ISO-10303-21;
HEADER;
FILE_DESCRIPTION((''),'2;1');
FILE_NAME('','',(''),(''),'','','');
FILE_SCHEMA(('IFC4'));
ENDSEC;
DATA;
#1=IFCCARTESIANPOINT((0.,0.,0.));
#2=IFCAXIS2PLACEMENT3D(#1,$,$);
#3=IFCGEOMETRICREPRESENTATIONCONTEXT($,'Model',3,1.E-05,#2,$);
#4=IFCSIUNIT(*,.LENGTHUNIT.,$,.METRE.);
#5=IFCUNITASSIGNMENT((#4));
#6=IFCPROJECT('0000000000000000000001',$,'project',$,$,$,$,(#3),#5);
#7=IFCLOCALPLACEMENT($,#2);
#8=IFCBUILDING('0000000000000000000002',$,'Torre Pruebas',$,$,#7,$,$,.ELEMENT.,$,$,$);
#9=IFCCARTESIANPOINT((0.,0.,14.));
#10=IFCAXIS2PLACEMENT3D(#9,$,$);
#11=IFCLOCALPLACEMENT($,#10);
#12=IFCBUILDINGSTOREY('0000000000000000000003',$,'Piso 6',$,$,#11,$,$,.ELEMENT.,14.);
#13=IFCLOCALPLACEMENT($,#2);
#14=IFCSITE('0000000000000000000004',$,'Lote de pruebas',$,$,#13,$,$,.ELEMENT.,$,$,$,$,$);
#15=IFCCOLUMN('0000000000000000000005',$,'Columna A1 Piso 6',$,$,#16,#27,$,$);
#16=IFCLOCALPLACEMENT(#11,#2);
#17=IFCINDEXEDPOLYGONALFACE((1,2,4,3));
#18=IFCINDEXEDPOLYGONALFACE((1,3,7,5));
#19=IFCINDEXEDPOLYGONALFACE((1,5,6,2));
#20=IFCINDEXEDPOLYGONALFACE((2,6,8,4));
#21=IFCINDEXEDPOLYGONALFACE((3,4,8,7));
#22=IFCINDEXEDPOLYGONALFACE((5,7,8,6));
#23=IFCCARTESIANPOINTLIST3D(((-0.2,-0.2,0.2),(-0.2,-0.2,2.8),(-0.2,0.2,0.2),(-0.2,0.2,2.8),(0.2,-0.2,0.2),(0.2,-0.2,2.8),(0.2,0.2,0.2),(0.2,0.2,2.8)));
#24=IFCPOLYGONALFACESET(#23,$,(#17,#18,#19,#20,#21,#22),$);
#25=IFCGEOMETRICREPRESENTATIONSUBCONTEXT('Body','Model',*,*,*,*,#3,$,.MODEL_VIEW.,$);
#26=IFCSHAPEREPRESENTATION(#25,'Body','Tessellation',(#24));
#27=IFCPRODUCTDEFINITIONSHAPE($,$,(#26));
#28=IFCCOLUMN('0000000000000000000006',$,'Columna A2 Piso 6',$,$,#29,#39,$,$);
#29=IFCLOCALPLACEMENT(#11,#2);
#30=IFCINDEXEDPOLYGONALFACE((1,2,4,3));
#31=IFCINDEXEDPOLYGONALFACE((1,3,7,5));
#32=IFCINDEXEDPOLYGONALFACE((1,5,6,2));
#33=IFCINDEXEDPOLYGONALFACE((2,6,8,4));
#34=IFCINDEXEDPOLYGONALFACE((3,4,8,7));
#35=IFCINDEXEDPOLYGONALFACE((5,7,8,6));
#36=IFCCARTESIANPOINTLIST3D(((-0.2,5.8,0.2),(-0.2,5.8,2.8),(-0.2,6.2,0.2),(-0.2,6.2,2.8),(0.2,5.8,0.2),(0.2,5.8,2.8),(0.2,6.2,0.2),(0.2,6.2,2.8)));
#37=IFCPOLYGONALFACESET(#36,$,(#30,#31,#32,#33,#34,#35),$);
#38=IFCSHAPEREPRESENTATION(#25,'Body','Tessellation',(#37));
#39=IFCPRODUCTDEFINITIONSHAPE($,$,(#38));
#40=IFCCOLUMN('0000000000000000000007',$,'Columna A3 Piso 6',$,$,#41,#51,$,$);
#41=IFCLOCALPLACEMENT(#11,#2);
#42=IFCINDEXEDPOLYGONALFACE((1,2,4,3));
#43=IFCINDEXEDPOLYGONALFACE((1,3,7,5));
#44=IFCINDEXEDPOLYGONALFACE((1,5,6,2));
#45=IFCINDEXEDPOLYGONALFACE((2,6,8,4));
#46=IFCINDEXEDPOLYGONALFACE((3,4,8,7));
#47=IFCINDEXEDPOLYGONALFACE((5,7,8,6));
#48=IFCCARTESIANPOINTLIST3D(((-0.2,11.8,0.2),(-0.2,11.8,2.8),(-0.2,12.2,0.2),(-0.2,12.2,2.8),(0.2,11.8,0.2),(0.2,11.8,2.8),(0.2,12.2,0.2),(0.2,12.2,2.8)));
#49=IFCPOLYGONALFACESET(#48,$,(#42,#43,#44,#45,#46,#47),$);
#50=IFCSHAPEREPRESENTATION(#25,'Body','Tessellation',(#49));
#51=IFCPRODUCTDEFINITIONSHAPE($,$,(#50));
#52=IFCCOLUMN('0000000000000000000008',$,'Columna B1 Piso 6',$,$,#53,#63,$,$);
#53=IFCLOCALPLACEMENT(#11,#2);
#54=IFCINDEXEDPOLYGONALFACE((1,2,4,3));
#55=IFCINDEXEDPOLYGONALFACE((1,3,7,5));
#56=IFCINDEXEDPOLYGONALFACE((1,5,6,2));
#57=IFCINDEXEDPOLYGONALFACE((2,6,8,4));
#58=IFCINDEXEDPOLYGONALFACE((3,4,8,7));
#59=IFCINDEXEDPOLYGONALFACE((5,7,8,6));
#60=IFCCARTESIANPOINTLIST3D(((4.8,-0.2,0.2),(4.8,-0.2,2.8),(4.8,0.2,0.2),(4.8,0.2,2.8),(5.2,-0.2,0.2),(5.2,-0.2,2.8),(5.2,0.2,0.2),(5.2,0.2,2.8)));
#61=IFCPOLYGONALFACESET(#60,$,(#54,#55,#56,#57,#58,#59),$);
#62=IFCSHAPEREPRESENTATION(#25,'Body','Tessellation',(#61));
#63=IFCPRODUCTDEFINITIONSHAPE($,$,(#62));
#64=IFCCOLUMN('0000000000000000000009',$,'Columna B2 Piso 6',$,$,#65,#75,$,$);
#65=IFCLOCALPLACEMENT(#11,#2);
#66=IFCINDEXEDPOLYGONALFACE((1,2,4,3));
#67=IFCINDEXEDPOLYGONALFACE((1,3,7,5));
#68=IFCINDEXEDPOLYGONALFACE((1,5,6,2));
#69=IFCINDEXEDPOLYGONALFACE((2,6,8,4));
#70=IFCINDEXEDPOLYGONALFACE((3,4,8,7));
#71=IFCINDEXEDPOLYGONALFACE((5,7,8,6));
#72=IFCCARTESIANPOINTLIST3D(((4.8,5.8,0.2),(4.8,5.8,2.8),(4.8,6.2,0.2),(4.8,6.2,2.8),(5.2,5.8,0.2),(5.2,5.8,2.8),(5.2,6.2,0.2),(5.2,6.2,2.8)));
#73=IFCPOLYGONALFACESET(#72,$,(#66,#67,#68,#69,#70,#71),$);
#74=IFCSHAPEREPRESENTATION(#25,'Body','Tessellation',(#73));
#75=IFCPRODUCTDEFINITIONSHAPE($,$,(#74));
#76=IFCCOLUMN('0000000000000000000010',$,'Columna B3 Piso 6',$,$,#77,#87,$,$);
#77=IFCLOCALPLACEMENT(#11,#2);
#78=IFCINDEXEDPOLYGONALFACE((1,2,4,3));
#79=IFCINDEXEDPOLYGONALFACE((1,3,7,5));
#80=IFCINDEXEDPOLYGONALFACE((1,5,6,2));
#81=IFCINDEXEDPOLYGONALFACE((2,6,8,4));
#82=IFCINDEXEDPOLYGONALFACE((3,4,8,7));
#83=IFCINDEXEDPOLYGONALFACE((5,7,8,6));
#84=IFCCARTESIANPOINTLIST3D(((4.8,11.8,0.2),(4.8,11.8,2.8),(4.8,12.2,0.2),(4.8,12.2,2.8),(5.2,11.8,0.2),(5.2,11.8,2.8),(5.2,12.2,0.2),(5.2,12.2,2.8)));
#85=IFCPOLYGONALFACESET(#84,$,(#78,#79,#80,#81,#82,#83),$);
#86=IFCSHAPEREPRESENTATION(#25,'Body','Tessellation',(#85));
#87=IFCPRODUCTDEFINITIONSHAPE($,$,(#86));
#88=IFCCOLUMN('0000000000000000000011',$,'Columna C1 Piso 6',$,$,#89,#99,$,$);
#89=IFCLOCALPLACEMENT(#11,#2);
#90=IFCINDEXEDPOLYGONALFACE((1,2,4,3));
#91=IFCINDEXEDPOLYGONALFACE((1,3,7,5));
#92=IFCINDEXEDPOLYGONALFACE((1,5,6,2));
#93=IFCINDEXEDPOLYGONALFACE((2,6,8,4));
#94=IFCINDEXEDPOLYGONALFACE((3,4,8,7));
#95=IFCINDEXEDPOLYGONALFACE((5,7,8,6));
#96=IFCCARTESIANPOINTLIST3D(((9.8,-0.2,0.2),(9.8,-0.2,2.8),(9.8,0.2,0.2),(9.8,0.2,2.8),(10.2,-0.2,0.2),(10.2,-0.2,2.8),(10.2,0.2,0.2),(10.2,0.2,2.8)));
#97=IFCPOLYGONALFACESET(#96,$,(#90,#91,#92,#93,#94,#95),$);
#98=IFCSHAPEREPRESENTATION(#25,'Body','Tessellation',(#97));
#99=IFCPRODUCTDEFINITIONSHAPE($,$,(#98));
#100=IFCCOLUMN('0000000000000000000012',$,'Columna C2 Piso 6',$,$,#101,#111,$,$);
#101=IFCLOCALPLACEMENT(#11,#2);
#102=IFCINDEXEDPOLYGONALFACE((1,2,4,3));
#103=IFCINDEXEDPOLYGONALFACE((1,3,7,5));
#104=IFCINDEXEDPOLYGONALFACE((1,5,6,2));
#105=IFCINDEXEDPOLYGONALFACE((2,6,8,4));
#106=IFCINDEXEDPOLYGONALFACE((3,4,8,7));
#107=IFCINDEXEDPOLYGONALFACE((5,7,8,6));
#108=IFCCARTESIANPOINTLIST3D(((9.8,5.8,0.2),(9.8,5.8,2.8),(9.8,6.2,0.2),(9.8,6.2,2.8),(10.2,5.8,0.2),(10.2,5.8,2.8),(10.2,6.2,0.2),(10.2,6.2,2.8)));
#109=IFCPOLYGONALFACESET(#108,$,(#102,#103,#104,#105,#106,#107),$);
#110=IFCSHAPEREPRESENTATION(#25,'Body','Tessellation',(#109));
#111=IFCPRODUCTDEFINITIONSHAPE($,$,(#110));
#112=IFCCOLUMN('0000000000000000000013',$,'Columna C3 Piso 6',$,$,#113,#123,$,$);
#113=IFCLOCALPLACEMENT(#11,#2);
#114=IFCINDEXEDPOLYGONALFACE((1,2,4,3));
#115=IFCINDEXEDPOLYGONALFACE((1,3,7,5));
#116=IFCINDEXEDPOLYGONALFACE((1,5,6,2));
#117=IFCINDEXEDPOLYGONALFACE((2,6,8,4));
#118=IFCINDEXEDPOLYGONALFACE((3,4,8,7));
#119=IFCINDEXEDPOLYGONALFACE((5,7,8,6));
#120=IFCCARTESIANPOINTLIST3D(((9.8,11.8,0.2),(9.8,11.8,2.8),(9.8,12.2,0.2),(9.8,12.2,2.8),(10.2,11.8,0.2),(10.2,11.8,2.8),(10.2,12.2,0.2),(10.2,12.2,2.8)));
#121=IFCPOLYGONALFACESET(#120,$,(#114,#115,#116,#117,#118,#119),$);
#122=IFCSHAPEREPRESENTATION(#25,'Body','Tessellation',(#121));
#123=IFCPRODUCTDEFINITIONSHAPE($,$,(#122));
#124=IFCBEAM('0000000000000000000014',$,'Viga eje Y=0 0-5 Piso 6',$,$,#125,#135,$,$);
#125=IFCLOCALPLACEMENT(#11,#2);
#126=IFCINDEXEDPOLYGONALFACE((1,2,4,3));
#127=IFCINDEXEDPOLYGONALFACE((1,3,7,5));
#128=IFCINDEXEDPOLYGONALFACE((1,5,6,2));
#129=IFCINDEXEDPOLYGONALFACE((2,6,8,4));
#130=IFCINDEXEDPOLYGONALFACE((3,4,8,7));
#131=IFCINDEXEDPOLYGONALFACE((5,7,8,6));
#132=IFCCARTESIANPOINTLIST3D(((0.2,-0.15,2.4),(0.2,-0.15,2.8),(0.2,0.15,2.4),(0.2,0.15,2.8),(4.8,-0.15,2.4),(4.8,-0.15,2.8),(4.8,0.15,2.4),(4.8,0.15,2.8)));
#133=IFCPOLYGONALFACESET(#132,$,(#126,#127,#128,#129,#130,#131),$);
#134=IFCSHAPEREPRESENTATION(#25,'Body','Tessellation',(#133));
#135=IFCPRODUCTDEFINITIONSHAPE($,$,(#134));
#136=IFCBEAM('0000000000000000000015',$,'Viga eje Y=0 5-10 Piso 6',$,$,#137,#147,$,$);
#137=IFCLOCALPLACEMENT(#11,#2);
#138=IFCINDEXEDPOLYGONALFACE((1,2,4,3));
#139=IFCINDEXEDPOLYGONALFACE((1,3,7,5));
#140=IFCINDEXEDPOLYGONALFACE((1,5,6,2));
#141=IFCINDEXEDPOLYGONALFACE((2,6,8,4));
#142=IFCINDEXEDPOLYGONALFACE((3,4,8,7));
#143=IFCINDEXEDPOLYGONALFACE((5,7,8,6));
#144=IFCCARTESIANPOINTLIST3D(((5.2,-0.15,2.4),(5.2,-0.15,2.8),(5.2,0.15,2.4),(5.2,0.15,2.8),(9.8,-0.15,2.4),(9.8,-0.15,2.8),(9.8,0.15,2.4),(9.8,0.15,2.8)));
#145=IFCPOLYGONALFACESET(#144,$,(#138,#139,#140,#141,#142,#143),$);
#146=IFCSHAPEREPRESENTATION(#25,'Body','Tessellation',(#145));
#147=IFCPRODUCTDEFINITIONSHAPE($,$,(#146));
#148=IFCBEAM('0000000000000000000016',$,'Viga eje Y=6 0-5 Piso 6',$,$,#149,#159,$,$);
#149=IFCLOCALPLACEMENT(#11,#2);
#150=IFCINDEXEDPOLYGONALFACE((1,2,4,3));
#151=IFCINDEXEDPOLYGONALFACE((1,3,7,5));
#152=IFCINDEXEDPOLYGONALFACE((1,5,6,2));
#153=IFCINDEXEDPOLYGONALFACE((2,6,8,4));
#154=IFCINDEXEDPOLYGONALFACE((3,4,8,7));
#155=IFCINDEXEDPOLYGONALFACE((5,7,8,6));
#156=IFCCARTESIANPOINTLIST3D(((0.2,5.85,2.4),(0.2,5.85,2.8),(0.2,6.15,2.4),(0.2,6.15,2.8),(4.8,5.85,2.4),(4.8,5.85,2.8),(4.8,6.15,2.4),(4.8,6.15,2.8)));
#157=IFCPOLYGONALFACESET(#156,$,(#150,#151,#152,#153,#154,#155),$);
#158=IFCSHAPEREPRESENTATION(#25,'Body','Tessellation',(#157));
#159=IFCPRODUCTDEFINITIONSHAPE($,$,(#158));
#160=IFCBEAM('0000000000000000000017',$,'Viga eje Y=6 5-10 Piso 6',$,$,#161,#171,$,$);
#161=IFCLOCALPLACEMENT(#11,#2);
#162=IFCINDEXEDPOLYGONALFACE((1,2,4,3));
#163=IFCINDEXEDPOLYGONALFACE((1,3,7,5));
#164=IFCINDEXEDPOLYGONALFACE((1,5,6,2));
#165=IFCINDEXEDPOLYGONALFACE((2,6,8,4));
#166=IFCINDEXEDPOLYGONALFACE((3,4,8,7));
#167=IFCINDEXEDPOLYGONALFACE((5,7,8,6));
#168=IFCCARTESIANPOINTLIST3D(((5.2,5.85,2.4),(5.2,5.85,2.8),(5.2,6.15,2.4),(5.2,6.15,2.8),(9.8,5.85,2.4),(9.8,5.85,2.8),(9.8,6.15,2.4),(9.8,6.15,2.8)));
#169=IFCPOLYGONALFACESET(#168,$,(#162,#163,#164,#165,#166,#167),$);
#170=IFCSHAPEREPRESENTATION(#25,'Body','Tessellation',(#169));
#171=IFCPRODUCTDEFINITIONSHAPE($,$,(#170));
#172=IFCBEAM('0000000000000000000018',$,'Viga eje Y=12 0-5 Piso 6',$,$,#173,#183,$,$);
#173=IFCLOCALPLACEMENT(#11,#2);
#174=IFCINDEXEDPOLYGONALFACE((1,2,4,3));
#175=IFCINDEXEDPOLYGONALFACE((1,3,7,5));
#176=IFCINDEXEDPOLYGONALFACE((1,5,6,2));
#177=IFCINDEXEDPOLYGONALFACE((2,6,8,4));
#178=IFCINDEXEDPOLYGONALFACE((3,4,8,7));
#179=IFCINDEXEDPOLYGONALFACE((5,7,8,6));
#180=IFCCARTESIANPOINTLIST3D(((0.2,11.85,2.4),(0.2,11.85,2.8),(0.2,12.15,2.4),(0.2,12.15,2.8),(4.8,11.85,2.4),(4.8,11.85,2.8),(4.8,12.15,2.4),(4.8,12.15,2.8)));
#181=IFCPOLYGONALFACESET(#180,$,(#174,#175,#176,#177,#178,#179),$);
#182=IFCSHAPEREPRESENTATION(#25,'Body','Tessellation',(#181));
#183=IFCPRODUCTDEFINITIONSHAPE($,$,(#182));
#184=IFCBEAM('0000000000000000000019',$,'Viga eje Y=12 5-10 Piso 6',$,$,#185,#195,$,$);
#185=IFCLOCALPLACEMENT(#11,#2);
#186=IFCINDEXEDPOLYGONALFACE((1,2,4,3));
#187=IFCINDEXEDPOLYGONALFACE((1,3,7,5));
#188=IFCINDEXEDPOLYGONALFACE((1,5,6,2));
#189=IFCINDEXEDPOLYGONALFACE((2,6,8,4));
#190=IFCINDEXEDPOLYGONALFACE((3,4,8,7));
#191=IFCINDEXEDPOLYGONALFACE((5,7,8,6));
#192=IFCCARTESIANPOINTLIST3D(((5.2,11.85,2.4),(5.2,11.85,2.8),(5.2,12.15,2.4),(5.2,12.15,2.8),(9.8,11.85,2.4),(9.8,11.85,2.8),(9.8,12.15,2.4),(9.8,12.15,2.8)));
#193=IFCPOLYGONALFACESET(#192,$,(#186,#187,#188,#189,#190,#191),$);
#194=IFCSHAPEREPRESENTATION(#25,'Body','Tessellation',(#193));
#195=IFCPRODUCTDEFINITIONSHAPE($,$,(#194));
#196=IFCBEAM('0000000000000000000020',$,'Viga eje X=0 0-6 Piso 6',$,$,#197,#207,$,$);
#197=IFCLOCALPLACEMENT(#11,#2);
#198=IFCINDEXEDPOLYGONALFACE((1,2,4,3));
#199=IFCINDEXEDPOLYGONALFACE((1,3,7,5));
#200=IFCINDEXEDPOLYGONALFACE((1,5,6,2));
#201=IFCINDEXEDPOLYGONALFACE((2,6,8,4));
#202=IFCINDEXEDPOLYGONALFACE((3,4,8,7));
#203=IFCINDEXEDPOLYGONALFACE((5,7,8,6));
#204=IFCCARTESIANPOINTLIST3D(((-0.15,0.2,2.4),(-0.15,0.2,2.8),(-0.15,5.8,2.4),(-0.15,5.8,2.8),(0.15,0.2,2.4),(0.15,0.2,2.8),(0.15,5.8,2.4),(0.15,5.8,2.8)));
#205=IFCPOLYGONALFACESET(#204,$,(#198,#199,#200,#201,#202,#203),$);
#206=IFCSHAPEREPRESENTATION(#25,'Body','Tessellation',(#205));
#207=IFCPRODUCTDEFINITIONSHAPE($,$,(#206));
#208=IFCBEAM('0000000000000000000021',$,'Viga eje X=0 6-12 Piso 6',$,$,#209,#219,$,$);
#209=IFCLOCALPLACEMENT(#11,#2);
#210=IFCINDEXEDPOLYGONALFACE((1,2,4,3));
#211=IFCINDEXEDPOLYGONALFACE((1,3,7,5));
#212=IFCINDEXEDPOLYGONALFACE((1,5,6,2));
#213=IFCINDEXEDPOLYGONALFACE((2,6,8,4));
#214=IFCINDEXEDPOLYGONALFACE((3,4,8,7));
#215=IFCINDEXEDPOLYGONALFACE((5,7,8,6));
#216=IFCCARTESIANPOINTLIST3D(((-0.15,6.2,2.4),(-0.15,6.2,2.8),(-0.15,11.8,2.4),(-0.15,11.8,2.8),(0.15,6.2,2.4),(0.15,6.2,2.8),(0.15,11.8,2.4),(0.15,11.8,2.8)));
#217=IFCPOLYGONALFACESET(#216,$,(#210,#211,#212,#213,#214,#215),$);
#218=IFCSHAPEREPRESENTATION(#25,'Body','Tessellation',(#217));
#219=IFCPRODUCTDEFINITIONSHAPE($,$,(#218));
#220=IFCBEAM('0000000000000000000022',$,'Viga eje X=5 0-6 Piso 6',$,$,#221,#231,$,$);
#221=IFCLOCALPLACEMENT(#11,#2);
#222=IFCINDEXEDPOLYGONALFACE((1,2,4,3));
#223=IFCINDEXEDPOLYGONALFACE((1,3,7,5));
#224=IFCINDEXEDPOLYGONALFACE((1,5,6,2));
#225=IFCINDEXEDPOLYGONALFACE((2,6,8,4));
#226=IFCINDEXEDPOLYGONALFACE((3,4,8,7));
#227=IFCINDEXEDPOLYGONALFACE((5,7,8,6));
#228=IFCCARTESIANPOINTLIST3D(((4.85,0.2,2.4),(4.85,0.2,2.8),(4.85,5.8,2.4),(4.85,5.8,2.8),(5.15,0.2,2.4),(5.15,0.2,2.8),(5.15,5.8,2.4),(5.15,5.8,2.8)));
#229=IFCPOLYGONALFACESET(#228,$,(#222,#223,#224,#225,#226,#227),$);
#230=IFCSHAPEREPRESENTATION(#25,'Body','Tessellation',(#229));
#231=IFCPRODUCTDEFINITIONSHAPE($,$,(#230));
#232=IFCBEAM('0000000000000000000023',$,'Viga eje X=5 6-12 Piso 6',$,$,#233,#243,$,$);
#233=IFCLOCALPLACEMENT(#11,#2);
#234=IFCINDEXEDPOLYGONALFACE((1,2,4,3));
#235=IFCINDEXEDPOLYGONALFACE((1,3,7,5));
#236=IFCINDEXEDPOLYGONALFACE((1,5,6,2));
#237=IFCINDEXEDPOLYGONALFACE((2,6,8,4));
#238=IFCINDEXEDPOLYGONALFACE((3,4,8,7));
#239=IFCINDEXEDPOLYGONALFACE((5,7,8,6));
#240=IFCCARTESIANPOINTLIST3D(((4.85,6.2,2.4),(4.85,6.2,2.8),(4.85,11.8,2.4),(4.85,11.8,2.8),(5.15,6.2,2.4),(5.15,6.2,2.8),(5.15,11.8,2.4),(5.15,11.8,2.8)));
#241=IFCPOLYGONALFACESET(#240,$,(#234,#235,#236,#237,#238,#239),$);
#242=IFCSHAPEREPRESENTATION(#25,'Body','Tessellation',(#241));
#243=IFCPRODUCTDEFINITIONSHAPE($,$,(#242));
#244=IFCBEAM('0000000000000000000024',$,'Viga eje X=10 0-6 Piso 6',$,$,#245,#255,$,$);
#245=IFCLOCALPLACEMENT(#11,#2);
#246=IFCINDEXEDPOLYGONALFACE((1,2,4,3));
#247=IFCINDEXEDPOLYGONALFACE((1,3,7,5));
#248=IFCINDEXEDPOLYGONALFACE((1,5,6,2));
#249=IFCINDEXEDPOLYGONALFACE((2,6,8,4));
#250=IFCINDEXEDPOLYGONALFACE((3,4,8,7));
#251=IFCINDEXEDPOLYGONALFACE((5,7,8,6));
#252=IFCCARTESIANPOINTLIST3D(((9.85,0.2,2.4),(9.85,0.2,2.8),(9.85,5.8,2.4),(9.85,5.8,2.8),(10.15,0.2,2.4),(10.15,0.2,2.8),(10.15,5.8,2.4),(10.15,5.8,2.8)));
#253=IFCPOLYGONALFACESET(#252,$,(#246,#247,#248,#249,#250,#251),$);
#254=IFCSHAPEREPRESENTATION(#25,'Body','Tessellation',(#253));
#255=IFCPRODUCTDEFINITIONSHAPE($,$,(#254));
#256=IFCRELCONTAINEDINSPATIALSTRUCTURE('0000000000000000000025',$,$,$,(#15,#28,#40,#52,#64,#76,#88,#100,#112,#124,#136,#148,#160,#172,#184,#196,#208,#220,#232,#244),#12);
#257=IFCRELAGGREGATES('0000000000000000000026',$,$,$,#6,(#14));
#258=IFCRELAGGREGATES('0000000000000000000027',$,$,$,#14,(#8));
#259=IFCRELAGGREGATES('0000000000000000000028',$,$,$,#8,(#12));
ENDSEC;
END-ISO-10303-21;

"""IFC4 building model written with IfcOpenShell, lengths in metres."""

from ifc_helpers import new_model, si_unit, frame, origin, origin_2d, place, context, subcontext, project, spatial, rectangle, extrude, element, save


model = new_model("IFC4")

# Units and contexts
model_context = context("Model", 3, precision=1e-05, world=origin())
body_context = subcontext(model_context, "Body", "Model", "MODEL_VIEW")
ifc_project = project(units=[si_unit("LENGTHUNIT", "METRE")], contexts=[model_context])

# Site, building, storey
site_placement = place(None, origin())
site = spatial("IfcSite", under=ifc_project, at=site_placement, Name="Lote de pruebas", CompositionType="ELEMENT")
building_placement = place(None, origin())
building = spatial("IfcBuilding", under=site, at=building_placement, Name="Torre Pruebas", CompositionType="ELEMENT")
storey_placement = place(None, frame((0.0, 0.0, 14.0)))
storey = spatial("IfcBuildingStorey", under=building, at=storey_placement, Name="Piso 6", CompositionType="ELEMENT", Elevation=14.0)

# Columns
for number, where, name in (
    (1, (0.0, 0.0, 14.2), "Columna A1 Piso 6"),
    (2, (0.0, 6.0, 14.2), "Columna A2 Piso 6"),
    (3, (0.0, 12.0, 14.2), "Columna A3 Piso 6"),
    (4, (5.0, 0.0, 14.2), "Columna B1 Piso 6"),
    (5, (5.0, 6.0, 14.2), "Columna B2 Piso 6"),
    (6, (5.0, 12.0, 14.2), "Columna B3 Piso 6"),
    (7, (10.0, 0.0, 14.2), "Columna C1 Piso 6"),
    (8, (10.0, 6.0, 14.2), "Columna C2 Piso 6"),
    (9, (10.0, 12.0, 14.2), "Columna C3 Piso 6"),
):
    element("IfcColumn", number, at=place(None, frame(where)), inside=storey, Name=name, context=body_context, shape_type="SweptSolid", body=[
        extrude(rectangle(XDim=0.4, YDim=0.4, at=origin_2d()), origin(), (0.0, 0.0, 1.0), 2.6),
    ])

# Beams
for number, where, name in (
    (10, (2.5, 0.0, 16.4), "Viga eje Y=0 0-5 Piso 6"),
    (11, (7.5, 0.0, 16.4), "Viga eje Y=0 5-10 Piso 6"),
    (12, (2.5, 6.0, 16.4), "Viga eje Y=6 0-5 Piso 6"),
    (13, (7.5, 6.0, 16.4), "Viga eje Y=6 5-10 Piso 6"),
    (14, (2.5, 12.0, 16.4), "Viga eje Y=12 0-5 Piso 6"),
    (15, (7.5, 12.0, 16.4), "Viga eje Y=12 5-10 Piso 6"),
):
    element("IfcBeam", number, at=place(None, frame(where)), inside=storey, Name=name, context=body_context, shape_type="SweptSolid", body=[
        extrude(rectangle(XDim=4.6, YDim=0.3, at=origin_2d()), origin(), (0.0, 0.0, 1.0), 0.4),
    ])
for number, where, name in (
    (16, (0.0, 3.0, 16.4), "Viga eje X=0 0-6 Piso 6"),
    (17, (0.0, 9.0, 16.4), "Viga eje X=0 6-12 Piso 6"),
    (18, (5.0, 3.0, 16.4), "Viga eje X=5 0-6 Piso 6"),
    (19, (5.0, 9.0, 16.4), "Viga eje X=5 6-12 Piso 6"),
    (20, (10.0, 3.0, 16.4), "Viga eje X=10 0-6 Piso 6"),
):
    element("IfcBeam", number, at=place(None, frame(where)), inside=storey, Name=name, context=body_context, shape_type="SweptSolid", body=[
        extrude(rectangle(XDim=0.3, YDim=5.6, at=origin_2d()), origin(), (0.0, 0.0, 1.0), 0.4),
    ])

save(model, "model.ifc")
